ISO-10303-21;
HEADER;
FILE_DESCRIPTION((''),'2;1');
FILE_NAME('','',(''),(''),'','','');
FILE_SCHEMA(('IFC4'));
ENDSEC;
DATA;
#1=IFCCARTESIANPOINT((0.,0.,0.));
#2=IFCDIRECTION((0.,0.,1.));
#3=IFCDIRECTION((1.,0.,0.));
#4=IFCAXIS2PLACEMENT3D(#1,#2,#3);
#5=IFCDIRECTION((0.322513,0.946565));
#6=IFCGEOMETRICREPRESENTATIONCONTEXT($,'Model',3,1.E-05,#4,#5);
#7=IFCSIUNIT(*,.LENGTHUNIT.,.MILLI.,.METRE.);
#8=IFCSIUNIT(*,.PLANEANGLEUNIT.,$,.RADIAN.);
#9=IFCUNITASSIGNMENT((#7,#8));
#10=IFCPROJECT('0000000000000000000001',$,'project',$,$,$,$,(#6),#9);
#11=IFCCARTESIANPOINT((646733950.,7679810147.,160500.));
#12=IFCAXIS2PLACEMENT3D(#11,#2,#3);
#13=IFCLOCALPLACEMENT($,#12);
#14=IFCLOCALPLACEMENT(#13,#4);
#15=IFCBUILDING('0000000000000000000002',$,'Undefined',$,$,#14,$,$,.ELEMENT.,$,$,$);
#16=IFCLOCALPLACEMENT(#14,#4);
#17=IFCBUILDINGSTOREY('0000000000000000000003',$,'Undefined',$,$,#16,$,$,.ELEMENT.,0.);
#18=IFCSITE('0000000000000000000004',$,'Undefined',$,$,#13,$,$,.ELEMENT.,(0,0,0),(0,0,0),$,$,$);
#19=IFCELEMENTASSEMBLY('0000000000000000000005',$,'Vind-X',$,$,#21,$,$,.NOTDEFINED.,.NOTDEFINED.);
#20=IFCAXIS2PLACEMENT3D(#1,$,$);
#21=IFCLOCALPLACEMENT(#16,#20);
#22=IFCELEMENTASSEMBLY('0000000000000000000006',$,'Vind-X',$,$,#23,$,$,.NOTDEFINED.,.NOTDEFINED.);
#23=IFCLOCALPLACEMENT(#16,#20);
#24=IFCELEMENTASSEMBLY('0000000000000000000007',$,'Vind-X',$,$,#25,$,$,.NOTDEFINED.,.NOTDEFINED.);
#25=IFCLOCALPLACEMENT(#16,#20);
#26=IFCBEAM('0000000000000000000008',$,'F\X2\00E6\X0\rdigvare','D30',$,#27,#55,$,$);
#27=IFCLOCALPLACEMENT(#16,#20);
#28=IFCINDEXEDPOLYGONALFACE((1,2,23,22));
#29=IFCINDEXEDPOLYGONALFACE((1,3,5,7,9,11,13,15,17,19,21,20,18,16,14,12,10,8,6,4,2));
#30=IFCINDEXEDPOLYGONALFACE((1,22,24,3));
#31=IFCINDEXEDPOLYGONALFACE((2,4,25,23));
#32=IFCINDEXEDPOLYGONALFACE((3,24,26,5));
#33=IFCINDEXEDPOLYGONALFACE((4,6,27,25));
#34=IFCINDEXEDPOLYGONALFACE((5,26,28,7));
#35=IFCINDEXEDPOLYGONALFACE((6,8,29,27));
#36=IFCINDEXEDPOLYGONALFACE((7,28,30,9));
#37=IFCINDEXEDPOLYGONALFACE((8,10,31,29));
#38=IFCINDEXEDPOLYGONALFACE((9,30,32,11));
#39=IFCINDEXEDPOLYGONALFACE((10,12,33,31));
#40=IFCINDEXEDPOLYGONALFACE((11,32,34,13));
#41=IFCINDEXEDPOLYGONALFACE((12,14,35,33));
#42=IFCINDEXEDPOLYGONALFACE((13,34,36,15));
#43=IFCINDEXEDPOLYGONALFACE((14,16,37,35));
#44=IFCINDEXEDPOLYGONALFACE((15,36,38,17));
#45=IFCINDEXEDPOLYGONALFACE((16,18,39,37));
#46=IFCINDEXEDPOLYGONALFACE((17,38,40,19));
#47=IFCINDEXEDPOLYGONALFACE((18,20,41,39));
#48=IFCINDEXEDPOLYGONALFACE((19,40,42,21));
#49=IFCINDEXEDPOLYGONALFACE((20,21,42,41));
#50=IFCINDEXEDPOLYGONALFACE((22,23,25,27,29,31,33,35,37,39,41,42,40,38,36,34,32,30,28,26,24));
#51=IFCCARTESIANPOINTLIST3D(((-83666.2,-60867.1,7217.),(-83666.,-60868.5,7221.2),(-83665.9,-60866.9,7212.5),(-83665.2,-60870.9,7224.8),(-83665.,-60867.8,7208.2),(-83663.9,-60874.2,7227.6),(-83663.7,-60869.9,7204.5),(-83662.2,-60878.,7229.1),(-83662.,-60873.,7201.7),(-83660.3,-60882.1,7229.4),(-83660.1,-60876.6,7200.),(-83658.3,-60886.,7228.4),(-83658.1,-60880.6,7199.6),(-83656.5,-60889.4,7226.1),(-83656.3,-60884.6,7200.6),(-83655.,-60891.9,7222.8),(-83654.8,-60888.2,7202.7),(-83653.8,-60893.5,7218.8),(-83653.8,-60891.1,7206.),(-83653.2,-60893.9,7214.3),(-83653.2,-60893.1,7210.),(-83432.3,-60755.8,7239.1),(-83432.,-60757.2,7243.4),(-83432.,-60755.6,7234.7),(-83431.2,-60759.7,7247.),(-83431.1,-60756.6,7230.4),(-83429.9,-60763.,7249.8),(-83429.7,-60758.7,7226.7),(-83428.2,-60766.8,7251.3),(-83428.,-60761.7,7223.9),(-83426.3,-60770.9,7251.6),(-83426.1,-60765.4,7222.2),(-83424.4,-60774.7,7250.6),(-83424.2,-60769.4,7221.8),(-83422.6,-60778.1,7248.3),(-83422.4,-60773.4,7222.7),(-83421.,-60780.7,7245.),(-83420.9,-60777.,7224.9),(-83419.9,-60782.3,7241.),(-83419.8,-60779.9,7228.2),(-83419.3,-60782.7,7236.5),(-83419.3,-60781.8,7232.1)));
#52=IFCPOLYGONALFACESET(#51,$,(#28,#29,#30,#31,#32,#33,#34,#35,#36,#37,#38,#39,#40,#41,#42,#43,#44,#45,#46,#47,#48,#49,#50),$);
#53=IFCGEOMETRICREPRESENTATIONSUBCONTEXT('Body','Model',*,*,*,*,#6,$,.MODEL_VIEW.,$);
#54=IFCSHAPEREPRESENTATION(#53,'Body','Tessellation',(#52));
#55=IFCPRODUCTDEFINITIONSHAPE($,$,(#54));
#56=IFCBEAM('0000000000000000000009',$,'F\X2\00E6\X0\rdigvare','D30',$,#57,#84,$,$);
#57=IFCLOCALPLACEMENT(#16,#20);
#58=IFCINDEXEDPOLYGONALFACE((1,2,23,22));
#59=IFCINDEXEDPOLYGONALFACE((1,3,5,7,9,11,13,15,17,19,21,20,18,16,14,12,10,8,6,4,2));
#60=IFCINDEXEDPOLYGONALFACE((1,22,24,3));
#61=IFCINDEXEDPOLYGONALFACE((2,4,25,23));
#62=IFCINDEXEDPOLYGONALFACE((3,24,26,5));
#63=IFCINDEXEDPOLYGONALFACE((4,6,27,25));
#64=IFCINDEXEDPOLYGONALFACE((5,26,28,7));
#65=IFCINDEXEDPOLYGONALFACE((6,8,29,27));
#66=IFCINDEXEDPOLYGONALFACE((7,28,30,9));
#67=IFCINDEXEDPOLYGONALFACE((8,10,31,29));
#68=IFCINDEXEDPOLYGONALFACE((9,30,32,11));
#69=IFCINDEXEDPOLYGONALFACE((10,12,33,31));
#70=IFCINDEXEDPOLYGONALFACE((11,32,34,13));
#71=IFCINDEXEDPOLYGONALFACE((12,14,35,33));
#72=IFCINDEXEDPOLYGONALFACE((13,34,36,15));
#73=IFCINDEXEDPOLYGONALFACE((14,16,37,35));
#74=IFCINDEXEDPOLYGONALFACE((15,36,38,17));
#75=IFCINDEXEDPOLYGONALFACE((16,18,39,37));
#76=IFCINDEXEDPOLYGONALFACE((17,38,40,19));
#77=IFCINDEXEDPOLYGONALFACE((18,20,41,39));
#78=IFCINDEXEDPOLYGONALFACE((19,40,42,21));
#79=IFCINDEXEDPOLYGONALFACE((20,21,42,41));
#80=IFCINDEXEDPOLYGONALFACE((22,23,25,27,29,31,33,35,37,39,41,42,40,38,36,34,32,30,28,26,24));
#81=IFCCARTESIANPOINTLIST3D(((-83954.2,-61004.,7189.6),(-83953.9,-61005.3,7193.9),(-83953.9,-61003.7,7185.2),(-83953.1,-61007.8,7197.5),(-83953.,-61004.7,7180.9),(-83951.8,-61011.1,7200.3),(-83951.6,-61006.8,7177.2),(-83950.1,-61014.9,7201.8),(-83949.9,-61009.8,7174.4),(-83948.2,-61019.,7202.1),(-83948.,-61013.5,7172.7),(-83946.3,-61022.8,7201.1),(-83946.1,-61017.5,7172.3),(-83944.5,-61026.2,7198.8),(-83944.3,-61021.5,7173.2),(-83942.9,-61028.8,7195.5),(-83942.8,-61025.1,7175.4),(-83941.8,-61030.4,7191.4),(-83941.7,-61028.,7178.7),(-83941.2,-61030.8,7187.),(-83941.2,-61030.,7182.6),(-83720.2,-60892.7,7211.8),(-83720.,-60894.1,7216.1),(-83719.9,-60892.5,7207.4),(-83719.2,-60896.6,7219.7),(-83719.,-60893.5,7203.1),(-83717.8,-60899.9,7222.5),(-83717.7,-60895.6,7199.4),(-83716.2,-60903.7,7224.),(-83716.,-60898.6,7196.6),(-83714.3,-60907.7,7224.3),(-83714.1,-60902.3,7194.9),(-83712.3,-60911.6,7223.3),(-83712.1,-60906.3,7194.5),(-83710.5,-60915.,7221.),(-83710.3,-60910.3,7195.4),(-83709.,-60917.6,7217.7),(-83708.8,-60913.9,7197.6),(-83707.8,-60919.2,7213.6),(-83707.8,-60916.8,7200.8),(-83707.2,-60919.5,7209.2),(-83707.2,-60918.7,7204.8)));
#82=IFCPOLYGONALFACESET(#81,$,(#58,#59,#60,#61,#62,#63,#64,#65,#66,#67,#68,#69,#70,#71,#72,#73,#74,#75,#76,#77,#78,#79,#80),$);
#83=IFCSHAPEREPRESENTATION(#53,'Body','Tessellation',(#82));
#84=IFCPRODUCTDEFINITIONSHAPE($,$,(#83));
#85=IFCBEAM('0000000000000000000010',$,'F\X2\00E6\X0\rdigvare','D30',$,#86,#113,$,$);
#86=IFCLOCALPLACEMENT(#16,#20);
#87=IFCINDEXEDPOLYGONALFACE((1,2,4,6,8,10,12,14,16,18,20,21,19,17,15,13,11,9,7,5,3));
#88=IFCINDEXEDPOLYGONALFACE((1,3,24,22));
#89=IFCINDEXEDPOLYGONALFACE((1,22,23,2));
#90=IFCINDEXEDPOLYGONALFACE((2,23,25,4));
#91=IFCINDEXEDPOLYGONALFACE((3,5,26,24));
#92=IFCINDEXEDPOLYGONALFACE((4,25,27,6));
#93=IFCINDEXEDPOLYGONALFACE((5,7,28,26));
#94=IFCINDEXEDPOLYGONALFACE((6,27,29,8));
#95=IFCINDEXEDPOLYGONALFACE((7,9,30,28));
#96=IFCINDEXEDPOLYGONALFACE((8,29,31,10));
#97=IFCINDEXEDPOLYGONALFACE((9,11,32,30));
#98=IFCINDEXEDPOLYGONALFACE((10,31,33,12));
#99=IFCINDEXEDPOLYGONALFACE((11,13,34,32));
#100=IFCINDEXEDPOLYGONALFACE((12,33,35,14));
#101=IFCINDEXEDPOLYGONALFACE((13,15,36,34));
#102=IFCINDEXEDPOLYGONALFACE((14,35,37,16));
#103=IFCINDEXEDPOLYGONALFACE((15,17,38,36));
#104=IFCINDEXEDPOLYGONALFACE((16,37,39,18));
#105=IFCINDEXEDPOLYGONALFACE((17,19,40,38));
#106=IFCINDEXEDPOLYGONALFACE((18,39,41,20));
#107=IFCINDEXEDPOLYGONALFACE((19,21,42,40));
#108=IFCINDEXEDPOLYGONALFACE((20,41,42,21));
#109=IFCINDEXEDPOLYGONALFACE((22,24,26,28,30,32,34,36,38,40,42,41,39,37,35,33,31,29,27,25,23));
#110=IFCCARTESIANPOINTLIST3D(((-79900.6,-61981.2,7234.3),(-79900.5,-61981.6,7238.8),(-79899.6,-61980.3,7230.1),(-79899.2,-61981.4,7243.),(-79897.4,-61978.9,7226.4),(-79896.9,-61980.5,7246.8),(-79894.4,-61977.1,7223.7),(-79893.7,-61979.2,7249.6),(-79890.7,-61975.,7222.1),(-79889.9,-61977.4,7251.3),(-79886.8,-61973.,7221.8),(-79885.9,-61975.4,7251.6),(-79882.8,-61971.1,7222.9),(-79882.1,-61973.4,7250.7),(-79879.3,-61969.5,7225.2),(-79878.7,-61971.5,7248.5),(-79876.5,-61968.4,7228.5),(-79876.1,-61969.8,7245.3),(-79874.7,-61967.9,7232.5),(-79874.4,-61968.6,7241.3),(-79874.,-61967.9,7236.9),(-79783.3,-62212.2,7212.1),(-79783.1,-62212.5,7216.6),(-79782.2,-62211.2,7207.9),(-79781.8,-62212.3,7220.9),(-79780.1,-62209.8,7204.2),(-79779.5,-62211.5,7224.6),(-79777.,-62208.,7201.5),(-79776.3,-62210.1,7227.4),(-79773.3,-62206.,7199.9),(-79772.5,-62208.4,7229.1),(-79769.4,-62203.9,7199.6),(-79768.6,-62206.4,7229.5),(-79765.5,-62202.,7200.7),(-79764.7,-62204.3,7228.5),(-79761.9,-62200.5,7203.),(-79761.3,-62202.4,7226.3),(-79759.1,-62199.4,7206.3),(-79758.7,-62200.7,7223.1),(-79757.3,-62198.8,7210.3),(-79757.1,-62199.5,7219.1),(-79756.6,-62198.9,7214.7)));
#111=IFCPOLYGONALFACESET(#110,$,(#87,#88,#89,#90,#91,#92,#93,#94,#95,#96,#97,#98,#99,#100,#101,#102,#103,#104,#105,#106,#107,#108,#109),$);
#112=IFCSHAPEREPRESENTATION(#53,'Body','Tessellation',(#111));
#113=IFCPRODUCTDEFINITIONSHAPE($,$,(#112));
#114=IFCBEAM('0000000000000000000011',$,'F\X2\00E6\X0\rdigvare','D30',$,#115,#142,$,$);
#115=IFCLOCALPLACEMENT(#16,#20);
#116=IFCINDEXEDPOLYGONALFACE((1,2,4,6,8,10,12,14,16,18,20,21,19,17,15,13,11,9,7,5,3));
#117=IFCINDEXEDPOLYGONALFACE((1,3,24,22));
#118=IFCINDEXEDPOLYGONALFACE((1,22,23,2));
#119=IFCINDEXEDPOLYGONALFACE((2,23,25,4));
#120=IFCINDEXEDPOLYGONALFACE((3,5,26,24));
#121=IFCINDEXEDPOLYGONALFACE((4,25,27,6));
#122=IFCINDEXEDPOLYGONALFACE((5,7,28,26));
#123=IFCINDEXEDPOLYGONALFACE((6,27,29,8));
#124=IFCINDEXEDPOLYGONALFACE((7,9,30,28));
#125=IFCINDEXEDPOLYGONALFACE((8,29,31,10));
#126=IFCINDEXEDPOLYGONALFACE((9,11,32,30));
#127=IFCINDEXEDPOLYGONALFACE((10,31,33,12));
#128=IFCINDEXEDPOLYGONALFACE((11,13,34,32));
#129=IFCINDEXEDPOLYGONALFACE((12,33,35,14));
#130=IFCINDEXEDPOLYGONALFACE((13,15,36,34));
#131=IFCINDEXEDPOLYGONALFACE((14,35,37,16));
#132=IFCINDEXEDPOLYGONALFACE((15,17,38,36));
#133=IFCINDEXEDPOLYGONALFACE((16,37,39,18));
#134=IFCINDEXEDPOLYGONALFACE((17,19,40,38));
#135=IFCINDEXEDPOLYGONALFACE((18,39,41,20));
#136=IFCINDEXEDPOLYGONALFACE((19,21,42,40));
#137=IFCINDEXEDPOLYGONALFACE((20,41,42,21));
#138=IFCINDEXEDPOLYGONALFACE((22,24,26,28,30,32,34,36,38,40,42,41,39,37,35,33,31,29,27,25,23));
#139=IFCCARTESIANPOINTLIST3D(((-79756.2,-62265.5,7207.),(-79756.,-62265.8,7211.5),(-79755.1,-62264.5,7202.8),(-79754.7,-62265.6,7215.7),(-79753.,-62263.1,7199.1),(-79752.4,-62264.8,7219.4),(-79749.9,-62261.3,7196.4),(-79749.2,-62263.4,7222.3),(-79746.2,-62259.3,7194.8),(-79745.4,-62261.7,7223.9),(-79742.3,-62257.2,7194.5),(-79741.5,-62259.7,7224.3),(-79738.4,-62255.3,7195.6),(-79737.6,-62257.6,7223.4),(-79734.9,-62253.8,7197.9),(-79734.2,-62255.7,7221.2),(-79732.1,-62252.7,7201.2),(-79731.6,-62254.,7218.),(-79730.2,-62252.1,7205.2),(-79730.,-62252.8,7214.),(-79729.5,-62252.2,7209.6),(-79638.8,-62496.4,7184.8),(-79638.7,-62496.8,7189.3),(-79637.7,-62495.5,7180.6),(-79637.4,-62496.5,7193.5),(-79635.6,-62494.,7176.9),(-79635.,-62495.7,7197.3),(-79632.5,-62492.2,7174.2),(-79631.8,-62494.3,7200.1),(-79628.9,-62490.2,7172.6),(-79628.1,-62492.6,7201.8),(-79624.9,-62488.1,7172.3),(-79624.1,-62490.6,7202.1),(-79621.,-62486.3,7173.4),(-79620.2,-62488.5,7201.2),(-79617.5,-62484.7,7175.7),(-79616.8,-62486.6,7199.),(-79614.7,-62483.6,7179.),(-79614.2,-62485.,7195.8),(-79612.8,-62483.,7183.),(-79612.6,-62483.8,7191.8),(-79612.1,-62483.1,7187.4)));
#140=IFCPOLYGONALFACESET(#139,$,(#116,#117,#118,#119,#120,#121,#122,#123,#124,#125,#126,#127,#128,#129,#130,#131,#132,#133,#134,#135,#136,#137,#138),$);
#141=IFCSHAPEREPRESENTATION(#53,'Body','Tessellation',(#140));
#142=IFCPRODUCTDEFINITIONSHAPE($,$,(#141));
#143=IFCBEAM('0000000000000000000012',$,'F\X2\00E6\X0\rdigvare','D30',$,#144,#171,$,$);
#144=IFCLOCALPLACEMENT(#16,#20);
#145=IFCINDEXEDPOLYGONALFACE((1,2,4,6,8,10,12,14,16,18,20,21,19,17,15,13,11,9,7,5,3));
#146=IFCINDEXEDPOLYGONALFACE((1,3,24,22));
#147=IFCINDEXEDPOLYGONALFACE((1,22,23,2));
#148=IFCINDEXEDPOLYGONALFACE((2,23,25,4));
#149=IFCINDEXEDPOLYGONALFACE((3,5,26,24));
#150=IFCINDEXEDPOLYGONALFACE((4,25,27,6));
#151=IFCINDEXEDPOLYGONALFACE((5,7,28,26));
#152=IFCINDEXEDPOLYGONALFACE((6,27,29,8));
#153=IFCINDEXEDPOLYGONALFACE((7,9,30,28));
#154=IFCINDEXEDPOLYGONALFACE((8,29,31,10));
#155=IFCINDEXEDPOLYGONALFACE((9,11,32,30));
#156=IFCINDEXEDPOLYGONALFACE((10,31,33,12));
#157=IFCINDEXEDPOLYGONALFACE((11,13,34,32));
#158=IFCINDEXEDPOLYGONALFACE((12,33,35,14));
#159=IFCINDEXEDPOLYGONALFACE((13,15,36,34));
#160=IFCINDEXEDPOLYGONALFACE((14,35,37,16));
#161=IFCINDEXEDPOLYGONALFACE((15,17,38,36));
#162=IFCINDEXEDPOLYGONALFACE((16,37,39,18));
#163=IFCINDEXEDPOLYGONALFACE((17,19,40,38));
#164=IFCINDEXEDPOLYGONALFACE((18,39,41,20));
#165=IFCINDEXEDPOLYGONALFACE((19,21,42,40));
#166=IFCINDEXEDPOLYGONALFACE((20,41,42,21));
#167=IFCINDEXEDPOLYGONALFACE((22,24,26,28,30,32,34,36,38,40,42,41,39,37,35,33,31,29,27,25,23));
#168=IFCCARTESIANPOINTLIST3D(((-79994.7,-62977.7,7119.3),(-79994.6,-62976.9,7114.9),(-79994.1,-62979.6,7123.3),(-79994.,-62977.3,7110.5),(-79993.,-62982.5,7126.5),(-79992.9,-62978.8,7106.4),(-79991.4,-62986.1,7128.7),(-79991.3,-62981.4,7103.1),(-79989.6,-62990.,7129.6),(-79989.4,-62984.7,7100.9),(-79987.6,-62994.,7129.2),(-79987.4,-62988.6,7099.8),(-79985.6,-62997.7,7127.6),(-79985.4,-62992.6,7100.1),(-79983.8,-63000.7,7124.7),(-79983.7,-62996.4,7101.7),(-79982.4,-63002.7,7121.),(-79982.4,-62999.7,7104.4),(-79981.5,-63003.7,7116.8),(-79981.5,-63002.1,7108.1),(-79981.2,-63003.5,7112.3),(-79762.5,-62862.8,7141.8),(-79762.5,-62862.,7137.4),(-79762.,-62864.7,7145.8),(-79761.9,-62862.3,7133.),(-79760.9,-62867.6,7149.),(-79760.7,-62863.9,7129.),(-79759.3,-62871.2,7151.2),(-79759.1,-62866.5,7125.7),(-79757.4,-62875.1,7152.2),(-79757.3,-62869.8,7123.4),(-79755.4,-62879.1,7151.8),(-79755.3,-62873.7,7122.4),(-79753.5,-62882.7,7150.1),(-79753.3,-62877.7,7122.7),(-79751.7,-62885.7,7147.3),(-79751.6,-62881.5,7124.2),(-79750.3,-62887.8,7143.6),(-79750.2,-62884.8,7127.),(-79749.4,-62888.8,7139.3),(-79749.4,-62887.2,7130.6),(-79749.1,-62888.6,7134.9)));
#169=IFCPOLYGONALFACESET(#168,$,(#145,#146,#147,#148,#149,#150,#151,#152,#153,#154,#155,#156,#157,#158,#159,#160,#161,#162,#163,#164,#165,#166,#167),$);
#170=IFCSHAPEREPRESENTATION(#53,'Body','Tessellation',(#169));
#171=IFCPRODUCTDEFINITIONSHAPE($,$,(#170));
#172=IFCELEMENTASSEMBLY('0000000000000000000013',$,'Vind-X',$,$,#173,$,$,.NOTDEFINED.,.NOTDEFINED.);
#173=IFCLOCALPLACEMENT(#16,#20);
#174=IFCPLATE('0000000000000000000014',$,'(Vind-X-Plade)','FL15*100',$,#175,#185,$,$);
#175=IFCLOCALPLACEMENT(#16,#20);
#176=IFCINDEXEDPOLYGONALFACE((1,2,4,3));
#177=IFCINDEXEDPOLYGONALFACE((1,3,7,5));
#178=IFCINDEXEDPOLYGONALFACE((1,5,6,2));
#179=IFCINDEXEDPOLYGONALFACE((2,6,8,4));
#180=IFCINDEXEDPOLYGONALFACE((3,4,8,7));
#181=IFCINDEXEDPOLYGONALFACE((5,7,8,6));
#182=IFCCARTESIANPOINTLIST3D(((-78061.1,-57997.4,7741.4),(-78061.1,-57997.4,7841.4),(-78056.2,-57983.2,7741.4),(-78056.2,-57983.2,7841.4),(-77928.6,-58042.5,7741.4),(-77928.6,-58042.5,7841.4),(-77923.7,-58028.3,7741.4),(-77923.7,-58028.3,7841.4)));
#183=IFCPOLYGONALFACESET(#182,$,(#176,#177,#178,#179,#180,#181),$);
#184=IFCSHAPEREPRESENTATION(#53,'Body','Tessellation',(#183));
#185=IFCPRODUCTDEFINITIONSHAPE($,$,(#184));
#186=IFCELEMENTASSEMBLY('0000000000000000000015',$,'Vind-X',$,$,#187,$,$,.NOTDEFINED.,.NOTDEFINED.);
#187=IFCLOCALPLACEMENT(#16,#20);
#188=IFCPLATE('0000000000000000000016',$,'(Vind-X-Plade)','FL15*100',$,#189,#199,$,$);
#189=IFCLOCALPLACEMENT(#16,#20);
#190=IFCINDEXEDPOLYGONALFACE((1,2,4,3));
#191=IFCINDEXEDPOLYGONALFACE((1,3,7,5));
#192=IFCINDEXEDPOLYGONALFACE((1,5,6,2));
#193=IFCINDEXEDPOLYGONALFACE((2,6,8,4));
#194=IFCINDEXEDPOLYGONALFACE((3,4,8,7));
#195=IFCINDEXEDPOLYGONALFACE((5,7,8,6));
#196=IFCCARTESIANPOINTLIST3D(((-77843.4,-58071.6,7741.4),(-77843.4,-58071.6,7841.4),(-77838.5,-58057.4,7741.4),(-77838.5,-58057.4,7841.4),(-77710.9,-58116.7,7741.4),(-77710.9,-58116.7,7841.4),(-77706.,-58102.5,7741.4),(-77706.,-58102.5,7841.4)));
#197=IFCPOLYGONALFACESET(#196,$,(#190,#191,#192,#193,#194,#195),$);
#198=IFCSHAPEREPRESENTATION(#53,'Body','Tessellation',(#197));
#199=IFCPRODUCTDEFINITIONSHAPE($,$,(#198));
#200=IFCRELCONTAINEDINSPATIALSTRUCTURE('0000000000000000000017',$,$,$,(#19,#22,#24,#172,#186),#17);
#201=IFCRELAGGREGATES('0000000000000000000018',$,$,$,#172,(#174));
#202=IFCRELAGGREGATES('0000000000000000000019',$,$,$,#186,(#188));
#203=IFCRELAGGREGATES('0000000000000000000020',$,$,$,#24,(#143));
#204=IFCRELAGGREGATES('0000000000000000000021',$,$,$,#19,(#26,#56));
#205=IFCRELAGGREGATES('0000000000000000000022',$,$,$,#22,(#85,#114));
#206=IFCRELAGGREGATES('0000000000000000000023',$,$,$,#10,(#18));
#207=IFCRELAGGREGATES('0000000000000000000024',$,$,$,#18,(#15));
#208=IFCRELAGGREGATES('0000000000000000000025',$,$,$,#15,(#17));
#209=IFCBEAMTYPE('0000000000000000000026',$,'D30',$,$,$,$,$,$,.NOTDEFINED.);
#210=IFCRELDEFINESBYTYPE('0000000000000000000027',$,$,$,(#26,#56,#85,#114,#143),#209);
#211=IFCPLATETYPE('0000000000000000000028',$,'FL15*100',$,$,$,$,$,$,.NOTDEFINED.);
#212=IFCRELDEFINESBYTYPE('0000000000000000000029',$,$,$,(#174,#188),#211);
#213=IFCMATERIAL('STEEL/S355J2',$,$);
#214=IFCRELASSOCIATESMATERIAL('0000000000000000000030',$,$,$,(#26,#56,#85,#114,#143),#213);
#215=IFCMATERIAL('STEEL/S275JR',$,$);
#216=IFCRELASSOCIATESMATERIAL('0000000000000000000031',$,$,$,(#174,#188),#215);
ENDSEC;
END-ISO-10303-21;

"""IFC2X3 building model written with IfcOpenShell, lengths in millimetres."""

from ifc_helpers import new_model, si_unit, direction, frame, origin_with_axes, origin_2d_with_axis, place, context, subcontext, project, spatial, polyline, circle, outline, extrude, material, type_object, element, aggregate, save


model = new_model("IFC2X3")

# Units and contexts
model_context = context("Model", 3, precision=1e-05, world=origin_with_axes(), true_north=direction((0.322513, 0.946565)))
body_context = subcontext(model_context, "Body", "Model", "MODEL_VIEW")
ifc_project = project(units=[si_unit("LENGTHUNIT", "METRE", prefix="MILLI"), si_unit("PLANEANGLEUNIT", "RADIAN")], contexts=[model_context])

# Site, building, storey
site_placement = place(None, frame((646733950.0, 7679810147.0, 160500.0), z_axis=(0.0, 0.0, 1.0), x_axis=(1.0, 0.0, 0.0)))
site = spatial("IfcSite", under=ifc_project, at=site_placement, Name="Undefined", CompositionType="ELEMENT", RefLatitude=(0, 0, 0), RefLongitude=(0, 0, 0))
building_placement = place(site_placement, origin_with_axes())
building = spatial("IfcBuilding", under=site, at=building_placement, Name="Undefined", CompositionType="ELEMENT")
storey_placement = place(building_placement, origin_with_axes())
storey = spatial("IfcBuildingStorey", under=building, at=storey_placement, Name="Undefined", CompositionType="ELEMENT", Elevation=0.0)

# Element assemblies
assembly_1_placement = place(storey_placement, origin_with_axes())
assembly_1 = element("IfcElementAssembly", 1, at=assembly_1_placement, inside=storey, Name="Vind-X", AssemblyPlace="NOTDEFINED", PredefinedType="NOTDEFINED")
ifc_material_1 = material(Name="STEEL/S355J2")
assembly_2_placement = place(storey_placement, origin_with_axes())
assembly_2 = element("IfcElementAssembly", 2, at=assembly_2_placement, inside=storey, Name="Vind-X", AssemblyPlace="NOTDEFINED", PredefinedType="NOTDEFINED")

# Element assembly
assembly_3_placement = place(storey_placement, origin_with_axes())
assembly_3 = element("IfcElementAssembly", 3, at=assembly_3_placement, inside=storey, Name="Vind-X", AssemblyPlace="NOTDEFINED", PredefinedType="NOTDEFINED")

# Beams
beam_type_1 = type_object("IfcBeamType", Name="D30", PredefinedType="NOTDEFINED")
beam_1_placement = place(assembly_1_placement, frame((-83659.7, -60880.3, 7214.5), z_axis=(-0.434441, 0.89649, 0.08699), x_axis=(0.899842, 0.427784, 0.085352)))
beam_1 = element("IfcBeam", 4, at=beam_1_placement, type_object=beam_type_1, material=ifc_material_1, Name="Færdigvare", Description="D30", context=body_context, shape_type="SweptSolid", body=[
    extrude(circle(Radius=15.0, at=origin_2d_with_axis()), frame((260.0, 0.0, 0.0), z_axis=(-1.0, 0.0, 0.0), x_axis=(0.0, -1.0, 0.0)), (0.0, 0.0, 1.0), 260.0),
])
beam_2_placement = place(assembly_1_placement, frame((-83947.6, -61017.2, 7187.2), z_axis=(-0.434441, 0.89649, 0.08699), x_axis=(0.899843, 0.427783, 0.085352)))
beam_2 = element("IfcBeam", 5, at=beam_2_placement, type_object=beam_type_1, material=ifc_material_1, Name="Færdigvare", Description="D30", context=body_context, shape_type="SweptSolid", body=[
    extrude(circle(Radius=15.0, at=origin_2d_with_axis()), frame((260.0, 0.0, 0.0), z_axis=(-1.0, 0.0, 0.0), x_axis=(0.0, -1.0, 0.0)), (0.0, 0.0, 1.0), 260.0),
])
beam_3_placement = place(assembly_2_placement, frame((-79770.0, -62205.7, 7214.5), z_axis=(0.891425, 0.444742, 0.08699), x_axis=(-0.451461, 0.888199, 0.085352)))
beam_3 = element("IfcBeam", 6, at=beam_3_placement, type_object=beam_type_1, material=ifc_material_1, Name="Færdigvare", Description="D30", context=body_context, shape_type="SweptSolid", body=[
    extrude(circle(Radius=15.0, at=origin_2d_with_axis()), frame((260.0, 0.0, 0.0), z_axis=(-1.0, 0.0, 0.0), x_axis=(0.0, -1.0, 0.0)), (0.0, 0.0, 1.0), 260.0),
])
beam_4_placement = place(assembly_2_placement, frame((-79625.5, -62489.9, 7187.2), z_axis=(0.891424, 0.444742, 0.08699), x_axis=(-0.451462, 0.888199, 0.085352)))
beam_4 = element("IfcBeam", 7, at=beam_4_placement, type_object=beam_type_1, material=ifc_material_1, Name="Færdigvare", Description="D30", context=body_context, shape_type="SweptSolid", body=[
    extrude(circle(Radius=15.0, at=origin_2d_with_axis()), frame((260.0, 0.0, 0.0), z_axis=(-1.0, 0.0, 0.0), x_axis=(0.0, -1.0, 0.0)), (0.0, 0.0, 1.0), 260.0),
])
beam_5_placement = place(assembly_3_placement, frame((-79755.8, -62875.4, 7137.3), z_axis=(-0.448662, 0.88959, 0.085625), x_axis=(-0.892837, -0.441952, -0.086721)))
beam_5 = element("IfcBeam", 8, at=beam_5_placement, type_object=beam_type_1, material=ifc_material_1, Name="Færdigvare", Description="D30", context=body_context, shape_type="SweptSolid", body=[
    extrude(circle(Radius=15.0, at=origin_2d_with_axis()), frame((260.0, 0.0, 0.0), z_axis=(-1.0, 0.0, 0.0), x_axis=(0.0, -1.0, 0.0)), (0.0, 0.0, 1.0), 260.0),
])

# Element assemblies, plates
assembly_4_placement = place(storey_placement, origin_with_axes())
assembly_4 = element("IfcElementAssembly", 9, at=assembly_4_placement, inside=storey, Name="Vind-X", AssemblyPlace="NOTDEFINED", PredefinedType="NOTDEFINED")
ifc_material_2 = material(Name="STEEL/S275JR")
plate_type_1 = type_object("IfcPlateType", Name="FL15*100", PredefinedType="NOTDEFINED")
plate_1_placement = place(assembly_4_placement, frame((-77926.1, -58035.4, 7741.4), z_axis=(-0.322513, -0.946565, 0.0), x_axis=(0.0, 0.0, 1.0)))
plate_1 = element("IfcPlate", 10, at=plate_1_placement, type_object=plate_type_1, material=ifc_material_2, Name="(Vind-X-Plade)", Description="FL15*100", context=body_context, shape_type="SweptSolid", body=[
    extrude(outline(polyline([(0.0, 0.0), (100.0, 0.0), (100.0, 140.0), (0.0, 140.0), (0.0, 0.0)])), frame((0.0, 0.0, -7.5), z_axis=(0.0, 0.0, 1.0), x_axis=(1.0, 0.0, 0.0)), (0.0, 0.0, 1.0), 15.0),
])
aggregate(assembly_4, [plate_1])
assembly_5_placement = place(storey_placement, origin_with_axes())
assembly_5 = element("IfcElementAssembly", 11, at=assembly_5_placement, inside=storey, Name="Vind-X", AssemblyPlace="NOTDEFINED", PredefinedType="NOTDEFINED")
plate_2_placement = place(assembly_5_placement, frame((-77841.0, -58064.5, 7741.4), z_axis=(0.322513, 0.946565, 0.0), x_axis=(0.0, 0.0, 1.0)))
plate_2 = element("IfcPlate", 12, at=plate_2_placement, type_object=plate_type_1, material=ifc_material_2, Name="(Vind-X-Plade)", Description="FL15*100", context=body_context, shape_type="SweptSolid", body=[
    extrude(outline(polyline([(0.0, 0.0), (100.0, 0.0), (100.0, 140.0), (0.0, 140.0), (0.0, 0.0)])), frame((0.0, 0.0, -7.5), z_axis=(0.0, 0.0, 1.0), x_axis=(1.0, 0.0, 0.0)), (0.0, 0.0, 1.0), 15.0),
])

aggregate(assembly_5, [plate_2])

aggregate(assembly_3, [beam_5])

aggregate(assembly_1, [beam_1, beam_2])
aggregate(assembly_2, [beam_3, beam_4])

save(model, "model.ifc")
